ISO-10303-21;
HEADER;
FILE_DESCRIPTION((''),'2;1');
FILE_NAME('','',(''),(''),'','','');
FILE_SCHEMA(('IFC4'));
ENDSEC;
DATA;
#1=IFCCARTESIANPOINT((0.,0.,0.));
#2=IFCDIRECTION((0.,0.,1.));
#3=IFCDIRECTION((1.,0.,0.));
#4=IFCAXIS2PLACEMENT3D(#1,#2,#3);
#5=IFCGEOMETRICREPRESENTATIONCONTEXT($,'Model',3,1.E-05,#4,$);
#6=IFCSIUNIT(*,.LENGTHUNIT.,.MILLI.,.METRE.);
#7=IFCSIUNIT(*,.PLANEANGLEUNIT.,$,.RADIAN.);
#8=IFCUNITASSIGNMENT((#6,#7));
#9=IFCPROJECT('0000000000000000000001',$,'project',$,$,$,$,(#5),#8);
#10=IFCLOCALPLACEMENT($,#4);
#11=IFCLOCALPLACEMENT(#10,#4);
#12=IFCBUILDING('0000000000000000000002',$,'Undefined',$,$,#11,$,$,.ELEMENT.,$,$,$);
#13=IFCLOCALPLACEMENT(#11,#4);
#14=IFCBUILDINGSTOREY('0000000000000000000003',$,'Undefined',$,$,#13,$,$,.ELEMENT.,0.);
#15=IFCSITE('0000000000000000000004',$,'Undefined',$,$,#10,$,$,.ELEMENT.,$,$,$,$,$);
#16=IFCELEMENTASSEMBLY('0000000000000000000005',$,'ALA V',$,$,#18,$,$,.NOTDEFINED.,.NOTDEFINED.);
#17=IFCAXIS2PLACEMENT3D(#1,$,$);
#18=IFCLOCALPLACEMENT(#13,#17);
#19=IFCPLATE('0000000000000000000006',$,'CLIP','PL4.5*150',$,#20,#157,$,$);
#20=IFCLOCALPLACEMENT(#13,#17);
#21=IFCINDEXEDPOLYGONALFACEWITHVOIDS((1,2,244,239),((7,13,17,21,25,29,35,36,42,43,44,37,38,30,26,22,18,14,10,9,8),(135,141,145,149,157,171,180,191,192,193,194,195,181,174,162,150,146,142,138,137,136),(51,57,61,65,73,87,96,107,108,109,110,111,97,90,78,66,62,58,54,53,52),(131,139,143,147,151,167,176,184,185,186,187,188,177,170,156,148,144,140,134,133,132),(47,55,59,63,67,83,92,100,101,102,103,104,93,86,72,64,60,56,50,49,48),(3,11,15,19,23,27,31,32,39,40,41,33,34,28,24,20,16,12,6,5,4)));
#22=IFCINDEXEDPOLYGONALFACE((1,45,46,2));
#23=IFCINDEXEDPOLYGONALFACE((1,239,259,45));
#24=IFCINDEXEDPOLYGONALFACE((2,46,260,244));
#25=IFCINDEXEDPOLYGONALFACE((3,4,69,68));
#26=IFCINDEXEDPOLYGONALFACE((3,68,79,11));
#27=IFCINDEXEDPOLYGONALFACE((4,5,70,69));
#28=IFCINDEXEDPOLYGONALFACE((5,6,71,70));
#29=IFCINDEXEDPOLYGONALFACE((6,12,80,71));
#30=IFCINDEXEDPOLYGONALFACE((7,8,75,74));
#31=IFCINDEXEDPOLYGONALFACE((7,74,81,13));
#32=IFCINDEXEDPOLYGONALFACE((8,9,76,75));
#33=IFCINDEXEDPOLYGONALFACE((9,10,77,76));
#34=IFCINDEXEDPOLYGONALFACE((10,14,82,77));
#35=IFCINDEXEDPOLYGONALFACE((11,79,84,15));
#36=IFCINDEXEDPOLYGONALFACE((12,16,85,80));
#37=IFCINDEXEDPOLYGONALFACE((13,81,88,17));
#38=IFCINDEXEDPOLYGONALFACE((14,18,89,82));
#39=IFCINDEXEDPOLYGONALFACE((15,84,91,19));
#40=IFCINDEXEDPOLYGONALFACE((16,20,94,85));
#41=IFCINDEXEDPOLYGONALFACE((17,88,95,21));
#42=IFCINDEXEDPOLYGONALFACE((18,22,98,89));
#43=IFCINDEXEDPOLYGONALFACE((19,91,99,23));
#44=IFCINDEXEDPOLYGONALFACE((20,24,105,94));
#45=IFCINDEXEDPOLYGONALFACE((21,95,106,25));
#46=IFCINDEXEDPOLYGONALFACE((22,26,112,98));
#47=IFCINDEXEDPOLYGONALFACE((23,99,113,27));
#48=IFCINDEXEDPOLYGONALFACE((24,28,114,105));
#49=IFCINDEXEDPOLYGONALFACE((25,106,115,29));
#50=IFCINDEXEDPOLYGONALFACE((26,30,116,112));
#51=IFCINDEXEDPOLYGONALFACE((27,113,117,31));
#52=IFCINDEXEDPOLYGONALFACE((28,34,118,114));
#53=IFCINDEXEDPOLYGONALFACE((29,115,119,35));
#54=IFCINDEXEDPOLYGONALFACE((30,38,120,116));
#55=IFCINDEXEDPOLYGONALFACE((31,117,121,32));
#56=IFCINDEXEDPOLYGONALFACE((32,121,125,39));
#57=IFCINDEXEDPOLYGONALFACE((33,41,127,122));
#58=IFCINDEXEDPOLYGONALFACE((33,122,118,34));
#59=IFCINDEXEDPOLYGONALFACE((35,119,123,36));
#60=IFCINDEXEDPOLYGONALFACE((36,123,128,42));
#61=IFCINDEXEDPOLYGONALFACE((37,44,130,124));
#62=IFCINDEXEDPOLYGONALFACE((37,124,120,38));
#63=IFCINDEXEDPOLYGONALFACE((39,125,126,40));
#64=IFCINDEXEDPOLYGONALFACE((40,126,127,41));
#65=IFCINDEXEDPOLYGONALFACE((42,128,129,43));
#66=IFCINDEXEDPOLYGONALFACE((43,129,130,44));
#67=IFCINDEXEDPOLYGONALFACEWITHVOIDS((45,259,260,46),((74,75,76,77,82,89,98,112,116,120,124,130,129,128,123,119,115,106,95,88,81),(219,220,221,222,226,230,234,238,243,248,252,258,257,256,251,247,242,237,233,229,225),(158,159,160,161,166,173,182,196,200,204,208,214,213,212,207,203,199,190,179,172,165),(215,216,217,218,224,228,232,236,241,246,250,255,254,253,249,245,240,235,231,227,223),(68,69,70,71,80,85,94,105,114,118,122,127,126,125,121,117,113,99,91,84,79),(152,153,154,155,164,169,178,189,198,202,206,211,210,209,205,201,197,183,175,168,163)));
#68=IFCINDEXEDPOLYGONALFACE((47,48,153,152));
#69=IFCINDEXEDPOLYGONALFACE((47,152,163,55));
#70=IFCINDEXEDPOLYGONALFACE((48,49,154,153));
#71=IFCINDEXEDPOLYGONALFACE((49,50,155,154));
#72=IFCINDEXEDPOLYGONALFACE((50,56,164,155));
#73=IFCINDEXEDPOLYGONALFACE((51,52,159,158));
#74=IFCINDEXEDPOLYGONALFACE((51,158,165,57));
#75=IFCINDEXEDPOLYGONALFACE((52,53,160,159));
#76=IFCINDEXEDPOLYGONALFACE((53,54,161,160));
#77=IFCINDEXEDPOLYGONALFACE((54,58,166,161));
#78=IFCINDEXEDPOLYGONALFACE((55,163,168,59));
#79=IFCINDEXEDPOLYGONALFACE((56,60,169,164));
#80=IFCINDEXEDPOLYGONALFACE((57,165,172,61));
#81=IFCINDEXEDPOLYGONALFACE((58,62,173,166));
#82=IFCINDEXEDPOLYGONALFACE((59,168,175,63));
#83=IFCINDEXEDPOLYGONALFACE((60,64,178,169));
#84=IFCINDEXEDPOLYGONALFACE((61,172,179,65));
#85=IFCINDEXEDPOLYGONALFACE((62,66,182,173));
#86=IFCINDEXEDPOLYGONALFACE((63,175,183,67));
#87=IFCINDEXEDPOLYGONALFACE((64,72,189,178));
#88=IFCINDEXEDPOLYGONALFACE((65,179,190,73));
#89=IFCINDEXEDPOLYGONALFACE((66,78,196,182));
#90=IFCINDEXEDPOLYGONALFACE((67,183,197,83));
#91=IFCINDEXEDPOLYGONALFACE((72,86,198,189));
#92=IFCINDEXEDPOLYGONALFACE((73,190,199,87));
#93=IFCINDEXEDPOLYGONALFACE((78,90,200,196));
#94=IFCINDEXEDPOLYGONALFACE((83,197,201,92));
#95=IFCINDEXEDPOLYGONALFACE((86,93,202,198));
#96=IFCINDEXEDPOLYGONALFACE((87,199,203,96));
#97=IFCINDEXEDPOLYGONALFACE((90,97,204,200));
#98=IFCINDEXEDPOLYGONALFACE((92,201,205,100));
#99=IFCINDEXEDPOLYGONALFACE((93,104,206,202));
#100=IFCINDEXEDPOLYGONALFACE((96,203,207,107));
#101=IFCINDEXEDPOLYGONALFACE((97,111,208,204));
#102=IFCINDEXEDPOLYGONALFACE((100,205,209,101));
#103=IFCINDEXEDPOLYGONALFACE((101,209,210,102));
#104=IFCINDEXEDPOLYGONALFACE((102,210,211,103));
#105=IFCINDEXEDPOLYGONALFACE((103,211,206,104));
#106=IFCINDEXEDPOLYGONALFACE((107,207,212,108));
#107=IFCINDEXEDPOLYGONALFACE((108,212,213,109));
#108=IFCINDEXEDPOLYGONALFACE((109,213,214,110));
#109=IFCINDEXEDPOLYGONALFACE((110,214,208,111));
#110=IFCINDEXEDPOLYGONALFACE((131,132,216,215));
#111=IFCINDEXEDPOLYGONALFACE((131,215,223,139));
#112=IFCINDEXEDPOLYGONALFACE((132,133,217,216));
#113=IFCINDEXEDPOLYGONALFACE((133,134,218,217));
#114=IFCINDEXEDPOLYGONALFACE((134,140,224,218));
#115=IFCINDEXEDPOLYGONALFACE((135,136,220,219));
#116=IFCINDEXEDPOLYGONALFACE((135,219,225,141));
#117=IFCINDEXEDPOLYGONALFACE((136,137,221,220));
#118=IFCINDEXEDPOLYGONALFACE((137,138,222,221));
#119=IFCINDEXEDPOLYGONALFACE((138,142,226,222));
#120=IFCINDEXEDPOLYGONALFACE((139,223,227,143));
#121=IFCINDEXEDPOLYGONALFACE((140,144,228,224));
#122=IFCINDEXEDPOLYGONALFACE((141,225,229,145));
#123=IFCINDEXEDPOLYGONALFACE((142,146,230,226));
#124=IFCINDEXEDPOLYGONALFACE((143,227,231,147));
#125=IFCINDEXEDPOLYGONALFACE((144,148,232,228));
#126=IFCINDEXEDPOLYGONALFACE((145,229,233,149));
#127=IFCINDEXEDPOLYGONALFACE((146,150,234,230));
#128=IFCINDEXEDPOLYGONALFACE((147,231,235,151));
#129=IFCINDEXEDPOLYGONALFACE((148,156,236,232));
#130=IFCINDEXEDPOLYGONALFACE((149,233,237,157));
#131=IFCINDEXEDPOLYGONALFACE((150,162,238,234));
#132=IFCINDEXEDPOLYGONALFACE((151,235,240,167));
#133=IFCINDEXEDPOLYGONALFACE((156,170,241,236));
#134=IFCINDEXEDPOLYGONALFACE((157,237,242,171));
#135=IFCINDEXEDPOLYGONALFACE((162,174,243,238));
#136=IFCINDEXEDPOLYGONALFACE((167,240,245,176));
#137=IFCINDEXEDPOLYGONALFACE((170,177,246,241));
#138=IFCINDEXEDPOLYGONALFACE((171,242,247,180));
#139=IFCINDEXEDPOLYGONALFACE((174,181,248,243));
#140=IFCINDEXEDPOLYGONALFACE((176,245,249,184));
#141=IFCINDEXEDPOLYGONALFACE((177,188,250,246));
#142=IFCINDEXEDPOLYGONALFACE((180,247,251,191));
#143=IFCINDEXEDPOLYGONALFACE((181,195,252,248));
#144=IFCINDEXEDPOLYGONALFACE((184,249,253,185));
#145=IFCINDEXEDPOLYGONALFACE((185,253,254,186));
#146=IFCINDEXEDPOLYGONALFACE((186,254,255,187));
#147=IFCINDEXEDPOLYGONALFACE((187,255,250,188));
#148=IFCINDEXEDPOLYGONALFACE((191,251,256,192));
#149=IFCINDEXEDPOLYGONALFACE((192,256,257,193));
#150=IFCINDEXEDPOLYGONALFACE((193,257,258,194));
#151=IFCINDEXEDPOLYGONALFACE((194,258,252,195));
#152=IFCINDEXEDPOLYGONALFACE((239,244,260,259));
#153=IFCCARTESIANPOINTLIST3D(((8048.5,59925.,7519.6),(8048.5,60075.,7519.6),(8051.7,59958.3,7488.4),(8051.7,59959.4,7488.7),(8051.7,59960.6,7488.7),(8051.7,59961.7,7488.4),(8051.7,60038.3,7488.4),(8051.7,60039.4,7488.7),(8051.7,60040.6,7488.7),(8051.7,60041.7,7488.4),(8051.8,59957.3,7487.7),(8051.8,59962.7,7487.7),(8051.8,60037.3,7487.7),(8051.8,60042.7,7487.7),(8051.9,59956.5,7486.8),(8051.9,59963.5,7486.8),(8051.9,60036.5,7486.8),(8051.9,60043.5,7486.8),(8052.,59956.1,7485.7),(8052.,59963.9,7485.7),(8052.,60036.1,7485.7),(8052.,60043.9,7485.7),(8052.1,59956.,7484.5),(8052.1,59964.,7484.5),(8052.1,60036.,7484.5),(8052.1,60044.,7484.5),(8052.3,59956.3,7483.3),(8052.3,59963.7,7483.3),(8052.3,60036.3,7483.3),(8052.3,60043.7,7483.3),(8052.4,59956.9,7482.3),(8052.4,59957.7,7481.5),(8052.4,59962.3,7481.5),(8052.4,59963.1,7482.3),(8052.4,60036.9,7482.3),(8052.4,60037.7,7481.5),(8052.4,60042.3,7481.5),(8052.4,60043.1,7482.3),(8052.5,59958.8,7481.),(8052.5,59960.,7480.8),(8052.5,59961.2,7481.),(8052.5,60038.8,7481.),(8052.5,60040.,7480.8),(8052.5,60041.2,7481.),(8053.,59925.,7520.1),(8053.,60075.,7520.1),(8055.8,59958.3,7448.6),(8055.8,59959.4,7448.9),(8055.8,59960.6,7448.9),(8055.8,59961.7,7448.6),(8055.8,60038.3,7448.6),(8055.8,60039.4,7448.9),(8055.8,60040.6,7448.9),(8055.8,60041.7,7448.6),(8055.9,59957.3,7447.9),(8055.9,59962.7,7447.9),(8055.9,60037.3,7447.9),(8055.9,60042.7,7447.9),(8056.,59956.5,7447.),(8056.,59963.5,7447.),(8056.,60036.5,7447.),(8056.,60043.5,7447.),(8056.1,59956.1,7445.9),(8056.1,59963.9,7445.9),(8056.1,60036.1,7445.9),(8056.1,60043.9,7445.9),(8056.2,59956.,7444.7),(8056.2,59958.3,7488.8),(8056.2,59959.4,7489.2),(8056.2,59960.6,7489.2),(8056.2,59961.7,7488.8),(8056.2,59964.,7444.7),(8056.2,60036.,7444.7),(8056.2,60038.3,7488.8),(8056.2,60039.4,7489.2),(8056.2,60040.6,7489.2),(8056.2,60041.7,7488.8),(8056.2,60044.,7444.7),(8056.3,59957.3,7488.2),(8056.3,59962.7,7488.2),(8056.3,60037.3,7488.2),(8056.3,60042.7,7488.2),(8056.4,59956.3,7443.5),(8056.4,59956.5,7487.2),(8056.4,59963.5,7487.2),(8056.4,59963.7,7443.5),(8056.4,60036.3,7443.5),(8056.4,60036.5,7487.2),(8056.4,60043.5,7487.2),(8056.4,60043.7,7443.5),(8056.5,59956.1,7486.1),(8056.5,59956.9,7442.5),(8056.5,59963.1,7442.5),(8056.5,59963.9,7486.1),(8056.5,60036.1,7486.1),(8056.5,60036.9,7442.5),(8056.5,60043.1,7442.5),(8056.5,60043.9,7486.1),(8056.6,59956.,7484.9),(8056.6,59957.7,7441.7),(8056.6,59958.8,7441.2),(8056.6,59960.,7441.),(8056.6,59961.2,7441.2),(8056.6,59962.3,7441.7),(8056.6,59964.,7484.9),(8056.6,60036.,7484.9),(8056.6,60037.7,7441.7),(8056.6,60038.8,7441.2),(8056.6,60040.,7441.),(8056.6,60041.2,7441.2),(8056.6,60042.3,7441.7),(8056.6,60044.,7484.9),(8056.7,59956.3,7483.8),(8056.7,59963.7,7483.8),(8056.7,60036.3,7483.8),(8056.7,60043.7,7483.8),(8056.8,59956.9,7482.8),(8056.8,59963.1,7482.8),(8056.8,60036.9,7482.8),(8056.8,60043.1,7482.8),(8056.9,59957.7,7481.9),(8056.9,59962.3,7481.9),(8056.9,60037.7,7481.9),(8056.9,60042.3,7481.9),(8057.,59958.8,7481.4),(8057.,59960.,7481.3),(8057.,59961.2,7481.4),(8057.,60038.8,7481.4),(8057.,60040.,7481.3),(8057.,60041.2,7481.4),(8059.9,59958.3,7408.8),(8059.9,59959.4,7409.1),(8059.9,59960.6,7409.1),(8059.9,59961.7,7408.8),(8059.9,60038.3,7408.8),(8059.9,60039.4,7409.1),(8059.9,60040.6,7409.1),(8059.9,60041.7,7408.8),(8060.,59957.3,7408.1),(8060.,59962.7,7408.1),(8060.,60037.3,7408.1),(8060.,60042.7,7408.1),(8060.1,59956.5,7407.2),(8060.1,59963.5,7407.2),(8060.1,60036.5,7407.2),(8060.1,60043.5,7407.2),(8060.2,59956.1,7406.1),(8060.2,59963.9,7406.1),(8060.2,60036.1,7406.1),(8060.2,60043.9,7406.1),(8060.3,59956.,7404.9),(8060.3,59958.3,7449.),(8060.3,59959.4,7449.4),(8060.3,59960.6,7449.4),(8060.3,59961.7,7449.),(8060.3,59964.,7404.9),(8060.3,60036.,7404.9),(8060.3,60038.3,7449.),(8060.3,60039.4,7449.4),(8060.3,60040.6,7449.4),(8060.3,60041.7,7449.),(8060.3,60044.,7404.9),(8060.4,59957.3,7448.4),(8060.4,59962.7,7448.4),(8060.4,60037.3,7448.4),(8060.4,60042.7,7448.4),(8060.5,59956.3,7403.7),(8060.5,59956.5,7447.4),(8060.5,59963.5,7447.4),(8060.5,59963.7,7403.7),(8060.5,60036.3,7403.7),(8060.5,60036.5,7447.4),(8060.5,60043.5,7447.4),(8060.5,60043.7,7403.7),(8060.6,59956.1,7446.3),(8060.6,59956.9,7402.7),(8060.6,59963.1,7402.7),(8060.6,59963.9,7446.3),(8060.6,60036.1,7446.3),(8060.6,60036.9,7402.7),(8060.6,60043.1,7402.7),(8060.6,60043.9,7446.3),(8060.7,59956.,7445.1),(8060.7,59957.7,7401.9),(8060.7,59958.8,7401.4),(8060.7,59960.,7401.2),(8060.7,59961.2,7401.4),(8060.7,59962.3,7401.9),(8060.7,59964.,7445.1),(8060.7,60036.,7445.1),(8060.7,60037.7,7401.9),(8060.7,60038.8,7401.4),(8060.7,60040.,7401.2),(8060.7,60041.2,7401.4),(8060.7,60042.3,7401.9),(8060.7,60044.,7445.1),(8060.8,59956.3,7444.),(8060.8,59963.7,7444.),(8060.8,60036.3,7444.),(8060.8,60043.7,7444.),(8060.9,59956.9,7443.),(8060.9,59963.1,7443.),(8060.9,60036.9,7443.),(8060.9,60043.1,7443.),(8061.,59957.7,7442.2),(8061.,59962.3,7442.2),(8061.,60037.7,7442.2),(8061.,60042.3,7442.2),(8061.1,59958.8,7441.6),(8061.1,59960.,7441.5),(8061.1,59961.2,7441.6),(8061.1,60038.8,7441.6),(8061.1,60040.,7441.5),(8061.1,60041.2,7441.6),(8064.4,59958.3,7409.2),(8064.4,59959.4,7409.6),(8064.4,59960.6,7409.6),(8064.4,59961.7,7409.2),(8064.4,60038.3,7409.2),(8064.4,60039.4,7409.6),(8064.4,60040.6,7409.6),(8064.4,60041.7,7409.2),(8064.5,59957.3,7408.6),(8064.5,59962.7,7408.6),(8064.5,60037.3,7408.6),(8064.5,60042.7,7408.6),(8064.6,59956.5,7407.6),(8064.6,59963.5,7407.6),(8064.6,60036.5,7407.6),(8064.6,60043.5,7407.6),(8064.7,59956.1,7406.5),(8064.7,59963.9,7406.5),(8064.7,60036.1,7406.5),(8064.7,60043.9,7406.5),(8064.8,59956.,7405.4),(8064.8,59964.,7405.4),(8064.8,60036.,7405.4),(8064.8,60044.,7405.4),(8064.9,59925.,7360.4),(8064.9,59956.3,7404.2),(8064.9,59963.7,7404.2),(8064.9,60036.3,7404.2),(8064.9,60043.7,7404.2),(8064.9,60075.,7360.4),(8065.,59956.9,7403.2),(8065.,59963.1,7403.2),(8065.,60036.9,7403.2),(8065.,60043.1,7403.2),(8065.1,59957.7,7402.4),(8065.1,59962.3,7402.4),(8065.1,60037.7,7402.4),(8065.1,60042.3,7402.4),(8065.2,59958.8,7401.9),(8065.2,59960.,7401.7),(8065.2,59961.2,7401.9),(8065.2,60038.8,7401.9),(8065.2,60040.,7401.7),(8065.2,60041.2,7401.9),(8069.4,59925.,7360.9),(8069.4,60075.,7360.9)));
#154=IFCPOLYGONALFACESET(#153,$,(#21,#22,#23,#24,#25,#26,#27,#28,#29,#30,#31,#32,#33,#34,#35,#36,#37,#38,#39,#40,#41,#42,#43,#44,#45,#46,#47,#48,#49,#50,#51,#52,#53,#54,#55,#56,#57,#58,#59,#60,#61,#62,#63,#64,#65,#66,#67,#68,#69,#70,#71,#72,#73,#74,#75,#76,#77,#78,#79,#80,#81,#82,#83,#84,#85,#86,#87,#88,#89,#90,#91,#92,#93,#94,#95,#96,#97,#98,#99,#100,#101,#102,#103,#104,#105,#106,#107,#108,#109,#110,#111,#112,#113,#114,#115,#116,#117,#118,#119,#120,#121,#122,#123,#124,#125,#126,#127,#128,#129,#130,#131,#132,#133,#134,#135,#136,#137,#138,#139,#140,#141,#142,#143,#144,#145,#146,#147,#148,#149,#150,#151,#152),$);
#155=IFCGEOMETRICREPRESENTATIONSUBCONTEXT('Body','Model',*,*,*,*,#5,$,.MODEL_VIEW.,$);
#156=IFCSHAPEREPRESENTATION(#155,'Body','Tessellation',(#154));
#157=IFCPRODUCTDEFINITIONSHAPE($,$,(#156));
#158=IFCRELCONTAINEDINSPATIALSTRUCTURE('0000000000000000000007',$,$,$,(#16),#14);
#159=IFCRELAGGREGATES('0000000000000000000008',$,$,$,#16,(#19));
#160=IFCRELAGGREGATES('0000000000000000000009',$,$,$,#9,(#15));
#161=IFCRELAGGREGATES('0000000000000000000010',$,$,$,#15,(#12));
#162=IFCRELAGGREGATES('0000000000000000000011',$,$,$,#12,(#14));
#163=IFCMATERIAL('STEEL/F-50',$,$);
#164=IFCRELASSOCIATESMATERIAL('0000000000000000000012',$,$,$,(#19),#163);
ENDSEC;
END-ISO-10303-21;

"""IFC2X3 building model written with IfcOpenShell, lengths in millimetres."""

from ifc_helpers import new_model, si_unit, frame, origin_with_axes, origin_2d_with_axis, place, context, subcontext, project, spatial, polyline, circle, outline, extrude, source, transform, mapped, material, element, aggregate, save


model = new_model("IFC2X3")

# Units and contexts
model_context = context("Model", 3, precision=1e-05, world=origin_with_axes())
body_context = subcontext(model_context, "Body", "Model", "MODEL_VIEW")
ifc_project = project(units=[si_unit("LENGTHUNIT", "METRE", prefix="MILLI"), si_unit("PLANEANGLEUNIT", "RADIAN")], contexts=[model_context])

# Site, building, storey
site_placement = place(None, origin_with_axes())
site = spatial("IfcSite", under=ifc_project, at=site_placement, Name="Undefined", CompositionType="ELEMENT")
building_placement = place(site_placement, origin_with_axes())
building = spatial("IfcBuilding", under=site, at=building_placement, Name="Undefined", CompositionType="ELEMENT")
storey_placement = place(building_placement, origin_with_axes())
storey = spatial("IfcBuildingStorey", under=building, at=storey_placement, Name="Undefined", CompositionType="ELEMENT", Elevation=0.0)

# Element assembly
assembly_1_placement = place(storey_placement, origin_with_axes())
assembly_1 = element("IfcElementAssembly", 1, at=assembly_1_placement, inside=storey, Name="ALA V", AssemblyPlace="NOTDEFINED", PredefinedType="NOTDEFINED")
ifc_material_1 = material(Name="STEEL/F-50")

# Plate, openings
shared_shape_1 = source(origin_with_axes(), body_context, "Body", "SweptSolid", [
    extrude(circle(Radius=4.0, at=origin_2d_with_axis()), frame((0.0, -4.6, 0.0), z_axis=(0.0, 1.0, 0.0), x_axis=(1.0, 0.0, 0.0)), (0.0, 0.0, 1.0), 4.7),
])
plate_1_placement = place(assembly_1_placement, frame((8050.8, 59925.0, 7519.8), z_axis=(0.994727, 0.0, 0.102562), x_axis=(0.102562, 0.0, -0.994727)))
plate_1 = element("IfcPlate", 2, at=plate_1_placement, material=ifc_material_1, Name="CLIP", Description="PL4.5*150", context=body_context, shape_type="SweptSolid", body=[
    extrude(outline(polyline([(0.0, 0.0), (160.0, 0.0), (160.0, 150.0), (0.0, 150.0), (0.0, 0.0)])), frame((0.0, 0.0, -2.2), z_axis=(0.0, 0.0, 1.0), x_axis=(1.0, 0.0, 0.0)), (0.0, 0.0, 1.0), 4.5),
])
opening_1_placement = place(assembly_1_placement, frame((8052.1, 60040.0, 7484.8), z_axis=(0.0, 1.0, 0.0), x_axis=(0.102562, 0.0, -0.994727)))
element("IfcOpeningElement", 3, at=opening_1_placement, cuts=plate_1, ObjectType="Opening", context=body_context, shape_type="MappedRepresentation", body=[
    mapped(shared_shape_1, transform((0.0, 0.0, 0.0))),
    mapped(shared_shape_1, transform((40.0, 0.0, 0.0))),
    mapped(shared_shape_1, transform((80.0, 0.0, 0.0))),
])
opening_2_placement = place(assembly_1_placement, frame((8052.1, 59960.0, 7484.8), z_axis=(0.0, 1.0, 0.0), x_axis=(0.102562, 0.0, -0.994727)))
element("IfcOpeningElement", 4, at=opening_2_placement, cuts=plate_1, ObjectType="Opening", context=body_context, shape_type="MappedRepresentation", body=[
    mapped(shared_shape_1, transform((0.0, 0.0, 0.0))),
    mapped(shared_shape_1, transform((40.0, 0.0, 0.0))),
    mapped(shared_shape_1, transform((80.0, 0.0, 0.0))),
])

aggregate(assembly_1, [plate_1])

save(model, "model.ifc")
